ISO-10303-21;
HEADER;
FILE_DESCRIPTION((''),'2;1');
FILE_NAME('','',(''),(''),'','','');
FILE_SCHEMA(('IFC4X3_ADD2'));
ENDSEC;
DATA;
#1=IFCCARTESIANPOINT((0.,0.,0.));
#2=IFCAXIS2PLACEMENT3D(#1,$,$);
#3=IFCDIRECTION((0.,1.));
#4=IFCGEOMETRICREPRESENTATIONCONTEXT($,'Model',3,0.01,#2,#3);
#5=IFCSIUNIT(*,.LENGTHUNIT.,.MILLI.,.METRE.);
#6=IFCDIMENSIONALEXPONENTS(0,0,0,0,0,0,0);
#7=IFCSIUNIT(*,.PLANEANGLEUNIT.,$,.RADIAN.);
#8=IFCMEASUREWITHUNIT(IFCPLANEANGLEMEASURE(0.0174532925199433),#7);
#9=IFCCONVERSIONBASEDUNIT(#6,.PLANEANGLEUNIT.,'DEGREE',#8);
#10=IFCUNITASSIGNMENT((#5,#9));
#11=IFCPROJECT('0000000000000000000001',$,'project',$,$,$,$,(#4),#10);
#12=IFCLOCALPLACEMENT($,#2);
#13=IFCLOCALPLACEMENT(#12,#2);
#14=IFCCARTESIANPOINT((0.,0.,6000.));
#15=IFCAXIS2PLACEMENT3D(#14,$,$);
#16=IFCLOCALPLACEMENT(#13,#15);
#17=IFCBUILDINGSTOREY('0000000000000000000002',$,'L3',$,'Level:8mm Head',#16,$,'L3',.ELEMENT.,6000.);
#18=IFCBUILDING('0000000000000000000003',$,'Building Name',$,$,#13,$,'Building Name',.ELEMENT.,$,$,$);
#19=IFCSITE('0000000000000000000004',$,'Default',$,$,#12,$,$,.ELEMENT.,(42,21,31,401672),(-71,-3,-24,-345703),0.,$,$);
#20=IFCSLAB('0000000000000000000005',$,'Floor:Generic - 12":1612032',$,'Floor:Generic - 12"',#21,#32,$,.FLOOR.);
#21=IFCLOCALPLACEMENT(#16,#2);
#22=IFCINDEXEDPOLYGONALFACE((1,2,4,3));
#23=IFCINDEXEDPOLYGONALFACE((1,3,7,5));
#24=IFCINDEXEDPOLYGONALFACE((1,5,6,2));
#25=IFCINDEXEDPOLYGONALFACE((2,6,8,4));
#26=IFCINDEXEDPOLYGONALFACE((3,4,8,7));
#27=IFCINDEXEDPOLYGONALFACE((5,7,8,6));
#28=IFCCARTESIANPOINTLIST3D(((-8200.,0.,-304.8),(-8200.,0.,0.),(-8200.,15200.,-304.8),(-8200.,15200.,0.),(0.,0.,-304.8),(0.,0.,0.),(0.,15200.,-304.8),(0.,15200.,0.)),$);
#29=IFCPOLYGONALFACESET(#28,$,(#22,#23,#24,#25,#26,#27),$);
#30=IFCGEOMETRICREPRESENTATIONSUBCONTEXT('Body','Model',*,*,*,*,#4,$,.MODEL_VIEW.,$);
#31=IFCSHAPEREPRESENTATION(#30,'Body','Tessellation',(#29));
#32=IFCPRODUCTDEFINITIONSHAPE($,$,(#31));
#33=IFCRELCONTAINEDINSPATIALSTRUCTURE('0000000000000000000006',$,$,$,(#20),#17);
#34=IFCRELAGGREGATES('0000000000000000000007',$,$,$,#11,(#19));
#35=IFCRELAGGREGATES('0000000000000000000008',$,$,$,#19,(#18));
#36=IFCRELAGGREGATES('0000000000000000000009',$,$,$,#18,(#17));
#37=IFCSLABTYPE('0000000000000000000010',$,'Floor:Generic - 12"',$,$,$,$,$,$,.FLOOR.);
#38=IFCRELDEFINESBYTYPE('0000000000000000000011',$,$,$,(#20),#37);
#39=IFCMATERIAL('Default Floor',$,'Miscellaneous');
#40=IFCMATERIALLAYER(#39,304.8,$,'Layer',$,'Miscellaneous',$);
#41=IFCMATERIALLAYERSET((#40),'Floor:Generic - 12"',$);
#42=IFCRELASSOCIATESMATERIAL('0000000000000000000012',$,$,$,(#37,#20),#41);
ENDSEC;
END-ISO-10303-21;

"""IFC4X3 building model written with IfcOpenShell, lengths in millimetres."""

from ifc_helpers import new_model, entity, si_unit, converted_unit, direction, frame, frame_2d, origin, place, context, subcontext, project, spatial, rectangle, extrude, material, layer, layer_set, layer_usage, type_object, element, save


model = new_model("IFC4X3")

# Units and contexts
model_context = context("Model", 3, precision=0.01, world=origin(), true_north=direction((0.0, 1.0)))
body_context = subcontext(model_context, "Body", "Model", "MODEL_VIEW")
ifc_project = project(units=[si_unit("LENGTHUNIT", "METRE", prefix="MILLI"), converted_unit("PLANEANGLEUNIT", "DEGREE", entity("IfcPlaneAngleMeasure", 0.0174532925199433), si_unit("PLANEANGLEUNIT", "RADIAN"), dimensions=[0, 0, 0, 0, 0, 0, 0])], contexts=[model_context])

# Site, building, storey
site_placement = place(None, origin())
site = spatial("IfcSite", under=ifc_project, at=site_placement, Name="Default", CompositionType="ELEMENT", RefLatitude=(42, 21, 31, 401672), RefLongitude=(-71, -3, -24, -345703), RefElevation=0.0)
building_placement = place(site_placement, origin())
building = spatial("IfcBuilding", under=site, at=building_placement, Name="Building Name", LongName="Building Name", CompositionType="ELEMENT")
storey_placement = place(building_placement, frame((0.0, 0.0, 6000.0)))
storey = spatial("IfcBuildingStorey", under=building, at=storey_placement, Name="L3", ObjectType="Level:8mm Head", LongName="L3", CompositionType="ELEMENT", Elevation=6000.0)

# Slab
ifc_material = material(Name="Default Floor", Category="Miscellaneous")
ifc_layer = layer(ifc_material, 304.8, Name="Layer", Category="Miscellaneous")
ifc_layer_set = layer_set([ifc_layer], Name="Floor:Generic - 12\"")
ifc_layer_usage = layer_usage(ifc_layer_set, "AXIS3", "POSITIVE", 0.0)
slab_type = type_object("IfcSlabType", Name="Floor:Generic - 12\"", PredefinedType="FLOOR", material=ifc_layer_set)
slab_placement = place(storey_placement, origin())
element("IfcSlab", 1, at=slab_placement, inside=storey, type_object=slab_type, material=ifc_layer_usage, Name="Floor:Generic - 12\":1612032", ObjectType="Floor:Generic - 12\"", PredefinedType="FLOOR", context=body_context, shape_type="SweptSolid", body=[
    extrude(rectangle(XDim=15200.0, YDim=8200.0, at=frame_2d((0.0, 0.0), x_axis=(1.0, 0.0))), frame((-4100.0, 7600.0, 0.0), z_axis=(0.0, 0.0, -1.0), x_axis=(0.0, 1.0, 0.0)), (0.0, 0.0, 1.0), 304.8),
])

save(model, "model.ifc")
